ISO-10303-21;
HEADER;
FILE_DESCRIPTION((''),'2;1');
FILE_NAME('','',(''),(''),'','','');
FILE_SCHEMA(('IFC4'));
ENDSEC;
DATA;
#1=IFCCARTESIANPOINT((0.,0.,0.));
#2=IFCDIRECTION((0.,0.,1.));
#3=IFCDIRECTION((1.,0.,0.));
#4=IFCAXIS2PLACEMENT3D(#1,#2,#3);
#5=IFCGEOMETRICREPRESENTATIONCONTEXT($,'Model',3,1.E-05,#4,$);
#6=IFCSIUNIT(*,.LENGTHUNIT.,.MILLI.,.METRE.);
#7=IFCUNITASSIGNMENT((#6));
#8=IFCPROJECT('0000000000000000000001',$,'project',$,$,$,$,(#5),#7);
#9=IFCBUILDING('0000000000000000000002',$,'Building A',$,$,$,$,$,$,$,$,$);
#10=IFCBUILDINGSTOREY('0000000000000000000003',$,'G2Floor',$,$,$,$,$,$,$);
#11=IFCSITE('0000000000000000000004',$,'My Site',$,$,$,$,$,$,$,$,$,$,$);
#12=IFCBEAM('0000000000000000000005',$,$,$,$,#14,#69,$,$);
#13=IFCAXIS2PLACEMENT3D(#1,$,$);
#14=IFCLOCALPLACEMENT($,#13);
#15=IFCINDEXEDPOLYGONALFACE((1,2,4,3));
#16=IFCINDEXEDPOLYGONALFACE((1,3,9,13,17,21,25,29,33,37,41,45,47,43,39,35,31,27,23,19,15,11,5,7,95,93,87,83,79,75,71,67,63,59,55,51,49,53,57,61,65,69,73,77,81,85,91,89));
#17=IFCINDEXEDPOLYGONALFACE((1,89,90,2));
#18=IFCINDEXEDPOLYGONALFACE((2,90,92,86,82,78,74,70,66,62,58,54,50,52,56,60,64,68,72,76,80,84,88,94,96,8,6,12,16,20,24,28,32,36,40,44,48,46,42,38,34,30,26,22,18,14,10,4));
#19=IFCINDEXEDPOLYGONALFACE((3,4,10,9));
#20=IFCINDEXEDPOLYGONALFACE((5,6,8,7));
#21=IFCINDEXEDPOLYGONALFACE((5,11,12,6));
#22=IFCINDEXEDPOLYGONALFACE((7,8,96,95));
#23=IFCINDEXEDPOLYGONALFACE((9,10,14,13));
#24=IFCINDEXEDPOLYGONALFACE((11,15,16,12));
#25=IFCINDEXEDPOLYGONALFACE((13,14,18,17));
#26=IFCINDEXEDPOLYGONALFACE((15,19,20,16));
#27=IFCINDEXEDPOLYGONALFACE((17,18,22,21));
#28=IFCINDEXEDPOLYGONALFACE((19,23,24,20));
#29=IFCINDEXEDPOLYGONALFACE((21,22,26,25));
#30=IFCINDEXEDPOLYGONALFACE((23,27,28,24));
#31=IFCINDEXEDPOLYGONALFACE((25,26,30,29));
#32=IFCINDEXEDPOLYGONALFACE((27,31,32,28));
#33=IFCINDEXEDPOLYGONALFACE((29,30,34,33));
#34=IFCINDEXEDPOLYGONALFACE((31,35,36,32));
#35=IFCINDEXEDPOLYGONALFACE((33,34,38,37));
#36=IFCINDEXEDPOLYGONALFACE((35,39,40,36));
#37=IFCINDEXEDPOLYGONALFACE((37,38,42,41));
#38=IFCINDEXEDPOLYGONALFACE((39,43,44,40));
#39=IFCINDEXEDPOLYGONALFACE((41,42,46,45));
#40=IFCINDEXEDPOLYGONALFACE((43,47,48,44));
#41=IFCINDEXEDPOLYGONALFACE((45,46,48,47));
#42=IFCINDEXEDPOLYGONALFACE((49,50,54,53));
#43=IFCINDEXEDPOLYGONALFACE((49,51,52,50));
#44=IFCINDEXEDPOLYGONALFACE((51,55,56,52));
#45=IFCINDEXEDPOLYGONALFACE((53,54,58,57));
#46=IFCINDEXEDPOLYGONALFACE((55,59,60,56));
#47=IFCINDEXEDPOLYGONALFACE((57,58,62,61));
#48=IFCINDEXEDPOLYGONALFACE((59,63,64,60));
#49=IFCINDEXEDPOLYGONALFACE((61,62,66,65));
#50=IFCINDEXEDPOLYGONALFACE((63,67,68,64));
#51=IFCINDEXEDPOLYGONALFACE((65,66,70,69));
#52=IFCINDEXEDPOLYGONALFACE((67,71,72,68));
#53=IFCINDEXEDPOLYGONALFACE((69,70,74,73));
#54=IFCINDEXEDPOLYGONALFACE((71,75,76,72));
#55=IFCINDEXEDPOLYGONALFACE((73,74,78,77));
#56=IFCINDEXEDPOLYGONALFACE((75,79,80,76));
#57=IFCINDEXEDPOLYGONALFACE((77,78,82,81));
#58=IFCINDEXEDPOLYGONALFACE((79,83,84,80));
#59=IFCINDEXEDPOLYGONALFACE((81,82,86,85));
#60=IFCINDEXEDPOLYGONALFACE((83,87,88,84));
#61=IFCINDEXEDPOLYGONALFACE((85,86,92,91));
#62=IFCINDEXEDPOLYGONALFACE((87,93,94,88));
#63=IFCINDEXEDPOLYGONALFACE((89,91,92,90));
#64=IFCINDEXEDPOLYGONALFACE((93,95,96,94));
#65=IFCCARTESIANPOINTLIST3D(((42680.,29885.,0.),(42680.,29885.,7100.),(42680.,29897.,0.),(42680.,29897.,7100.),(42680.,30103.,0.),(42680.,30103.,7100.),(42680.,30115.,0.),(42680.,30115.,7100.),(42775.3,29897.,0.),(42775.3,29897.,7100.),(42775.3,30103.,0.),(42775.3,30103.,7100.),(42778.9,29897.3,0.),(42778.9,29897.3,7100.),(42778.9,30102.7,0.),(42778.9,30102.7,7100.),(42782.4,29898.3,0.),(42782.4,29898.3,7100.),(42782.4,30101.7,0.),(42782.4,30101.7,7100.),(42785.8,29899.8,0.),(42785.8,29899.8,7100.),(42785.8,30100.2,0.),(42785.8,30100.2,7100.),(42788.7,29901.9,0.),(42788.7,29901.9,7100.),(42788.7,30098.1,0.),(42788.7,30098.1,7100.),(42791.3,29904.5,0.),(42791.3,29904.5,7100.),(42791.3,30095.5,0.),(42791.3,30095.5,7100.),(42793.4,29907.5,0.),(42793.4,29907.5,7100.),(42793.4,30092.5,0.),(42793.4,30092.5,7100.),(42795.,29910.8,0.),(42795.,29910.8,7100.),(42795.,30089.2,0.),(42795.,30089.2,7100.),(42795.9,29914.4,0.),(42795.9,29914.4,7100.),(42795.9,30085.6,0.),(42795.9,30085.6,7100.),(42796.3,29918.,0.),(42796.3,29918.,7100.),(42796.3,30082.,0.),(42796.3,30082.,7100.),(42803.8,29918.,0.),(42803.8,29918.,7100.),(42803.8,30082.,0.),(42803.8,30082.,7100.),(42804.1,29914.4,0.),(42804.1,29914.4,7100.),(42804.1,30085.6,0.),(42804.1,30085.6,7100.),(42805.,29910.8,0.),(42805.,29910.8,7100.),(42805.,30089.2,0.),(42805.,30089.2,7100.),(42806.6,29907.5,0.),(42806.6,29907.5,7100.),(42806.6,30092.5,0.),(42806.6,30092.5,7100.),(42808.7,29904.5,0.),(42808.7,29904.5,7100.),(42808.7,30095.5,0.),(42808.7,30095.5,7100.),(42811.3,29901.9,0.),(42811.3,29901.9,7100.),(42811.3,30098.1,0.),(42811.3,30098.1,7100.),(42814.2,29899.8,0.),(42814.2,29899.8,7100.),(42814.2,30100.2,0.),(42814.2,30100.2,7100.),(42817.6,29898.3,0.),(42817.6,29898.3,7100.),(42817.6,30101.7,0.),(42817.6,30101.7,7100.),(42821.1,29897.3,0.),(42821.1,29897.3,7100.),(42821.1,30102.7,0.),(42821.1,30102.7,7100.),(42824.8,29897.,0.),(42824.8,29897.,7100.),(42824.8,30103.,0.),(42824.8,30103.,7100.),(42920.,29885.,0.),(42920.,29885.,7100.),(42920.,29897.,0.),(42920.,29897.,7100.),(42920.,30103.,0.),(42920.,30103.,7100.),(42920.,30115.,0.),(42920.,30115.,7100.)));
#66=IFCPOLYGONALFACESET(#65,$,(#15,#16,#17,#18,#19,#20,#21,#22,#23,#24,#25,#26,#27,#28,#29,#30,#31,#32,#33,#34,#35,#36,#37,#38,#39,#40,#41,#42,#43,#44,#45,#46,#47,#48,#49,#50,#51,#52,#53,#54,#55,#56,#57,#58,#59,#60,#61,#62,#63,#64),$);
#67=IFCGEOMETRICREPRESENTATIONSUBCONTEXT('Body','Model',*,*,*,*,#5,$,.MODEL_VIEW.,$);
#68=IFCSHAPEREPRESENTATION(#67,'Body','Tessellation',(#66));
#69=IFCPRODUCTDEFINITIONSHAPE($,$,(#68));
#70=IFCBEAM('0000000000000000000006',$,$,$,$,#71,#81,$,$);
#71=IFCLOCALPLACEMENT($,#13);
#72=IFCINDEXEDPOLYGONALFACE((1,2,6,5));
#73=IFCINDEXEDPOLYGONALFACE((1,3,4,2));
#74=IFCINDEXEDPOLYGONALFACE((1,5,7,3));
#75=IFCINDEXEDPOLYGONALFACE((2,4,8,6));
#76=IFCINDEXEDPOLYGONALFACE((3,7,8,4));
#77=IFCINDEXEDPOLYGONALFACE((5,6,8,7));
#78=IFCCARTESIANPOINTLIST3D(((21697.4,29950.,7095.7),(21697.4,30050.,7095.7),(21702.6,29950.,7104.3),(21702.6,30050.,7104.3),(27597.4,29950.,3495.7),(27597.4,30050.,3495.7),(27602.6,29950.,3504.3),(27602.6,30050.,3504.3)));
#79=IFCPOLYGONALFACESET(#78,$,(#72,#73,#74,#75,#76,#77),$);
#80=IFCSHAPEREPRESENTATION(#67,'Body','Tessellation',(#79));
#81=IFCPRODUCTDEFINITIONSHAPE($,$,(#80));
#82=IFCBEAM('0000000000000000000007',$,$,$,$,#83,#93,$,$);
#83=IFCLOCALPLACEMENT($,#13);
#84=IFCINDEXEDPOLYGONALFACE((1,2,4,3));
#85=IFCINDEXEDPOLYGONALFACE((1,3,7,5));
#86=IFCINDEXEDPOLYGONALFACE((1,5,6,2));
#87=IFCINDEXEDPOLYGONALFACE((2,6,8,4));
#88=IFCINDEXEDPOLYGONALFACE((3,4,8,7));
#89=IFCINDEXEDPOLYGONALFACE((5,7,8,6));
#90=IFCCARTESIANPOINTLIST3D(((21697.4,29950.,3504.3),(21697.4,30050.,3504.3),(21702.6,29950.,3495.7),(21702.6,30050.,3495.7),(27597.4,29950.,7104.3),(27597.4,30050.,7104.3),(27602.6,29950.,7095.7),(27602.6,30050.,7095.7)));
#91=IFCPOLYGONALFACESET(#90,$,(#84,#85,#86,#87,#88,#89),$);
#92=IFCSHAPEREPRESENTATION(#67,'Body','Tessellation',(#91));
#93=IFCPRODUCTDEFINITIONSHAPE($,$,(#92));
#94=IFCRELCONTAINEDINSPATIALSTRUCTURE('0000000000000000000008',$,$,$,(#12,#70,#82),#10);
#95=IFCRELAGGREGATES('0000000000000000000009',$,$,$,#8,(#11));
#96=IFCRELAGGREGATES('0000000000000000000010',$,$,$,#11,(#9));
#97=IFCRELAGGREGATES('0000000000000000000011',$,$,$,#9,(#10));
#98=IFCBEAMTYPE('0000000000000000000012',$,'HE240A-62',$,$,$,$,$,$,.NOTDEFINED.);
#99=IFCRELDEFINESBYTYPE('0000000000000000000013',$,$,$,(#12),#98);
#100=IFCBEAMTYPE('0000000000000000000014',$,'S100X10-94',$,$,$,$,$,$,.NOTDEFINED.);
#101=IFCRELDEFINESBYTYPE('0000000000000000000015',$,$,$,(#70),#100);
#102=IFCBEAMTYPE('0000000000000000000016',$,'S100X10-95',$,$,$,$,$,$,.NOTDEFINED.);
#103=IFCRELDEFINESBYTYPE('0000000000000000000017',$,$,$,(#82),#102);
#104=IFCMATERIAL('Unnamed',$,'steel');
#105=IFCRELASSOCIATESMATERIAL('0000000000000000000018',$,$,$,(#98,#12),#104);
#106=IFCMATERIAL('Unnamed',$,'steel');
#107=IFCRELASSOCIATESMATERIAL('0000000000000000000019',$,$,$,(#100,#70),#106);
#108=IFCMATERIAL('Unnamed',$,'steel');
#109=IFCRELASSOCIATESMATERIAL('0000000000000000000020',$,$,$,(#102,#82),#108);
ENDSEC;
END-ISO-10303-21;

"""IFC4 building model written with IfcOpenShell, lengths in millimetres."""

from ifc_helpers import new_model, si_unit, frame, origin_with_axes, place, context, subcontext, project, spatial, polyline, outline, extrude, material, material_profile, profile_set, profile_usage, type_object, element, save


model = new_model("IFC4")

# Units and contexts
model_context = context("Model", 3, precision=1e-05, world=origin_with_axes())
body_context = subcontext(model_context, "Body", "Model", "MODEL_VIEW")
ifc_project = project(units=[si_unit("LENGTHUNIT", "METRE", prefix="MILLI")], contexts=[model_context])

# Site, building, storey
site = spatial("IfcSite", under=ifc_project, Name="My Site")
building = spatial("IfcBuilding", under=site, Name="Building A")
storey = spatial("IfcBuildingStorey", under=building, Name="G2Floor")

# Beams
ifc_material_1 = material(Name="Unnamed", Category="steel")
ifc_material_profile_1 = material_profile(ifc_material_1, outline(polyline([(120.0, -115.0), (120.0, -103.0), (120.0, -103.0), (24.8, -103.0), (24.8, -103.0), (21.1, -102.7), (21.1, -102.7), (17.6, -101.7), (17.6, -101.7), (14.2, -100.2), (14.2, -100.2), (11.3, -98.1), (11.3, -98.1), (8.7, -95.5), (8.7, -95.5), (6.6, -92.5), (6.6, -92.5), (5.0, -89.2), (5.0, -89.2), (4.1, -85.6), (4.1, -85.6), (3.8, -82.0), (3.8, -82.0), (3.8, 82.0), (3.8, 82.0), (4.1, 85.6), (4.1, 85.6), (5.0, 89.2), (5.0, 89.2), (6.6, 92.5), (6.6, 92.5), (8.7, 95.5), (8.7, 95.5), (11.3, 98.1), (11.3, 98.1), (14.2, 100.2), (14.2, 100.2), (17.6, 101.7), (17.6, 101.7), (21.1, 102.7), (21.1, 102.7), (24.8, 103.0), (24.8, 103.0), (120.0, 103.0), (120.0, 103.0), (120.0, 115.0), (120.0, 115.0), (-120.0, 115.0), (-120.0, 115.0), (-120.0, 103.0), (-120.0, 103.0), (-24.8, 103.0), (-24.8, 103.0), (-21.1, 102.7), (-21.1, 102.7), (-17.6, 101.7), (-17.6, 101.7), (-14.2, 100.2), (-14.2, 100.2), (-11.3, 98.1), (-11.3, 98.1), (-8.7, 95.5), (-8.7, 95.5), (-6.6, 92.5), (-6.6, 92.5), (-5.0, 89.2), (-5.0, 89.2), (-4.1, 85.6), (-4.1, 85.6), (-3.8, 82.0), (-3.8, 82.0), (-3.8, -82.0), (-3.8, -82.0), (-4.1, -85.6), (-4.1, -85.6), (-5.0, -89.2), (-5.0, -89.2), (-6.6, -92.5), (-6.6, -92.5), (-8.7, -95.5), (-8.7, -95.5), (-11.3, -98.1), (-11.3, -98.1), (-14.2, -100.2), (-14.2, -100.2), (-17.6, -101.7), (-17.6, -101.7), (-21.1, -102.7), (-21.1, -102.7), (-24.8, -103.0), (-24.8, -103.0), (-120.0, -103.0), (-120.0, -103.0), (-120.0, -115.0), (-120.0, -115.0), (120.0, -115.0)])))
ifc_profile_set_1 = profile_set([ifc_material_profile_1], Name="HE240A-62")
ifc_profile_usage_1 = profile_usage(ifc_profile_set_1)
beam_type_1 = type_object("IfcBeamType", Name="HE240A-62", PredefinedType="NOTDEFINED", material=ifc_profile_set_1)
beam_1_placement = place(None, frame((42800.0, 30000.0, 0.0), z_axis=(0.0, 0.0, 1.0), x_axis=(1.0, 0.0, 0.0)))
element("IfcBeam", 1, at=beam_1_placement, inside=storey, type_object=beam_type_1, material=ifc_profile_usage_1, context=body_context, shape_type="SweptSolid", body=[
    extrude(outline(polyline([(120.0, -115.0), (120.0, -103.0), (120.0, -103.0), (24.8, -103.0), (24.8, -103.0), (21.1, -102.7), (21.1, -102.7), (17.6, -101.7), (17.6, -101.7), (14.2, -100.2), (14.2, -100.2), (11.3, -98.1), (11.3, -98.1), (8.7, -95.5), (8.7, -95.5), (6.6, -92.5), (6.6, -92.5), (5.0, -89.2), (5.0, -89.2), (4.1, -85.6), (4.1, -85.6), (3.8, -82.0), (3.8, -82.0), (3.8, 82.0), (3.8, 82.0), (4.1, 85.6), (4.1, 85.6), (5.0, 89.2), (5.0, 89.2), (6.6, 92.5), (6.6, 92.5), (8.7, 95.5), (8.7, 95.5), (11.3, 98.1), (11.3, 98.1), (14.2, 100.2), (14.2, 100.2), (17.6, 101.7), (17.6, 101.7), (21.1, 102.7), (21.1, 102.7), (24.8, 103.0), (24.8, 103.0), (120.0, 103.0), (120.0, 103.0), (120.0, 115.0), (120.0, 115.0), (-120.0, 115.0), (-120.0, 115.0), (-120.0, 103.0), (-120.0, 103.0), (-24.8, 103.0), (-24.8, 103.0), (-21.1, 102.7), (-21.1, 102.7), (-17.6, 101.7), (-17.6, 101.7), (-14.2, 100.2), (-14.2, 100.2), (-11.3, 98.1), (-11.3, 98.1), (-8.7, 95.5), (-8.7, 95.5), (-6.6, 92.5), (-6.6, 92.5), (-5.0, 89.2), (-5.0, 89.2), (-4.1, 85.6), (-4.1, 85.6), (-3.8, 82.0), (-3.8, 82.0), (-3.8, -82.0), (-3.8, -82.0), (-4.1, -85.6), (-4.1, -85.6), (-5.0, -89.2), (-5.0, -89.2), (-6.6, -92.5), (-6.6, -92.5), (-8.7, -95.5), (-8.7, -95.5), (-11.3, -98.1), (-11.3, -98.1), (-14.2, -100.2), (-14.2, -100.2), (-17.6, -101.7), (-17.6, -101.7), (-21.1, -102.7), (-21.1, -102.7), (-24.8, -103.0), (-24.8, -103.0), (-120.0, -103.0), (-120.0, -103.0), (-120.0, -115.0), (-120.0, -115.0), (120.0, -115.0)])), origin_with_axes(), (0.0, 0.0, 1.0), 7100.0),
])
ifc_material_2 = material(Name="Unnamed", Category="steel")
ifc_material_profile_2 = material_profile(ifc_material_2, outline(polyline([(50.0, -5.0), (50.0, 5.0), (50.0, 5.0), (-50.0, 5.0), (-50.0, 5.0), (-50.0, -5.0), (-50.0, -5.0), (50.0, -5.0)])))
ifc_profile_set_2 = profile_set([ifc_material_profile_2], Name="S100X10-94")
ifc_profile_usage_2 = profile_usage(ifc_profile_set_2)
beam_type_2 = type_object("IfcBeamType", Name="S100X10-94", PredefinedType="NOTDEFINED", material=ifc_profile_set_2)
beam_2_placement = place(None, frame((21700.0, 30000.0, 7100.0), z_axis=(0.853639, 0.0, -0.520865), x_axis=(0.0, -1.0, 0.0)))
element("IfcBeam", 2, at=beam_2_placement, inside=storey, type_object=beam_type_2, material=ifc_profile_usage_2, context=body_context, shape_type="SweptSolid", body=[
    extrude(outline(polyline([(50.0, -5.0), (50.0, 5.0), (50.0, 5.0), (-50.0, 5.0), (-50.0, 5.0), (-50.0, -5.0), (-50.0, -5.0), (50.0, -5.0)])), origin_with_axes(), (0.0, 0.0, 1.0), 6911.6),
])
ifc_material_3 = material(Name="Unnamed", Category="steel")
ifc_material_profile_3 = material_profile(ifc_material_3, outline(polyline([(50.0, -5.0), (50.0, 5.0), (50.0, 5.0), (-50.0, 5.0), (-50.0, 5.0), (-50.0, -5.0), (-50.0, -5.0), (50.0, -5.0)])))
ifc_profile_set_3 = profile_set([ifc_material_profile_3], Name="S100X10-95")
ifc_profile_usage_3 = profile_usage(ifc_profile_set_3)
beam_type_3 = type_object("IfcBeamType", Name="S100X10-95", PredefinedType="NOTDEFINED", material=ifc_profile_set_3)
beam_3_placement = place(None, frame((21700.0, 30000.0, 3500.0), z_axis=(0.853639, 0.0, 0.520865), x_axis=(0.0, -1.0, 0.0)))
element("IfcBeam", 3, at=beam_3_placement, inside=storey, type_object=beam_type_3, material=ifc_profile_usage_3, context=body_context, shape_type="SweptSolid", body=[
    extrude(outline(polyline([(50.0, -5.0), (50.0, 5.0), (50.0, 5.0), (-50.0, 5.0), (-50.0, 5.0), (-50.0, -5.0), (-50.0, -5.0), (50.0, -5.0)])), origin_with_axes(), (0.0, 0.0, 1.0), 6911.6),
])

save(model, "model.ifc")
